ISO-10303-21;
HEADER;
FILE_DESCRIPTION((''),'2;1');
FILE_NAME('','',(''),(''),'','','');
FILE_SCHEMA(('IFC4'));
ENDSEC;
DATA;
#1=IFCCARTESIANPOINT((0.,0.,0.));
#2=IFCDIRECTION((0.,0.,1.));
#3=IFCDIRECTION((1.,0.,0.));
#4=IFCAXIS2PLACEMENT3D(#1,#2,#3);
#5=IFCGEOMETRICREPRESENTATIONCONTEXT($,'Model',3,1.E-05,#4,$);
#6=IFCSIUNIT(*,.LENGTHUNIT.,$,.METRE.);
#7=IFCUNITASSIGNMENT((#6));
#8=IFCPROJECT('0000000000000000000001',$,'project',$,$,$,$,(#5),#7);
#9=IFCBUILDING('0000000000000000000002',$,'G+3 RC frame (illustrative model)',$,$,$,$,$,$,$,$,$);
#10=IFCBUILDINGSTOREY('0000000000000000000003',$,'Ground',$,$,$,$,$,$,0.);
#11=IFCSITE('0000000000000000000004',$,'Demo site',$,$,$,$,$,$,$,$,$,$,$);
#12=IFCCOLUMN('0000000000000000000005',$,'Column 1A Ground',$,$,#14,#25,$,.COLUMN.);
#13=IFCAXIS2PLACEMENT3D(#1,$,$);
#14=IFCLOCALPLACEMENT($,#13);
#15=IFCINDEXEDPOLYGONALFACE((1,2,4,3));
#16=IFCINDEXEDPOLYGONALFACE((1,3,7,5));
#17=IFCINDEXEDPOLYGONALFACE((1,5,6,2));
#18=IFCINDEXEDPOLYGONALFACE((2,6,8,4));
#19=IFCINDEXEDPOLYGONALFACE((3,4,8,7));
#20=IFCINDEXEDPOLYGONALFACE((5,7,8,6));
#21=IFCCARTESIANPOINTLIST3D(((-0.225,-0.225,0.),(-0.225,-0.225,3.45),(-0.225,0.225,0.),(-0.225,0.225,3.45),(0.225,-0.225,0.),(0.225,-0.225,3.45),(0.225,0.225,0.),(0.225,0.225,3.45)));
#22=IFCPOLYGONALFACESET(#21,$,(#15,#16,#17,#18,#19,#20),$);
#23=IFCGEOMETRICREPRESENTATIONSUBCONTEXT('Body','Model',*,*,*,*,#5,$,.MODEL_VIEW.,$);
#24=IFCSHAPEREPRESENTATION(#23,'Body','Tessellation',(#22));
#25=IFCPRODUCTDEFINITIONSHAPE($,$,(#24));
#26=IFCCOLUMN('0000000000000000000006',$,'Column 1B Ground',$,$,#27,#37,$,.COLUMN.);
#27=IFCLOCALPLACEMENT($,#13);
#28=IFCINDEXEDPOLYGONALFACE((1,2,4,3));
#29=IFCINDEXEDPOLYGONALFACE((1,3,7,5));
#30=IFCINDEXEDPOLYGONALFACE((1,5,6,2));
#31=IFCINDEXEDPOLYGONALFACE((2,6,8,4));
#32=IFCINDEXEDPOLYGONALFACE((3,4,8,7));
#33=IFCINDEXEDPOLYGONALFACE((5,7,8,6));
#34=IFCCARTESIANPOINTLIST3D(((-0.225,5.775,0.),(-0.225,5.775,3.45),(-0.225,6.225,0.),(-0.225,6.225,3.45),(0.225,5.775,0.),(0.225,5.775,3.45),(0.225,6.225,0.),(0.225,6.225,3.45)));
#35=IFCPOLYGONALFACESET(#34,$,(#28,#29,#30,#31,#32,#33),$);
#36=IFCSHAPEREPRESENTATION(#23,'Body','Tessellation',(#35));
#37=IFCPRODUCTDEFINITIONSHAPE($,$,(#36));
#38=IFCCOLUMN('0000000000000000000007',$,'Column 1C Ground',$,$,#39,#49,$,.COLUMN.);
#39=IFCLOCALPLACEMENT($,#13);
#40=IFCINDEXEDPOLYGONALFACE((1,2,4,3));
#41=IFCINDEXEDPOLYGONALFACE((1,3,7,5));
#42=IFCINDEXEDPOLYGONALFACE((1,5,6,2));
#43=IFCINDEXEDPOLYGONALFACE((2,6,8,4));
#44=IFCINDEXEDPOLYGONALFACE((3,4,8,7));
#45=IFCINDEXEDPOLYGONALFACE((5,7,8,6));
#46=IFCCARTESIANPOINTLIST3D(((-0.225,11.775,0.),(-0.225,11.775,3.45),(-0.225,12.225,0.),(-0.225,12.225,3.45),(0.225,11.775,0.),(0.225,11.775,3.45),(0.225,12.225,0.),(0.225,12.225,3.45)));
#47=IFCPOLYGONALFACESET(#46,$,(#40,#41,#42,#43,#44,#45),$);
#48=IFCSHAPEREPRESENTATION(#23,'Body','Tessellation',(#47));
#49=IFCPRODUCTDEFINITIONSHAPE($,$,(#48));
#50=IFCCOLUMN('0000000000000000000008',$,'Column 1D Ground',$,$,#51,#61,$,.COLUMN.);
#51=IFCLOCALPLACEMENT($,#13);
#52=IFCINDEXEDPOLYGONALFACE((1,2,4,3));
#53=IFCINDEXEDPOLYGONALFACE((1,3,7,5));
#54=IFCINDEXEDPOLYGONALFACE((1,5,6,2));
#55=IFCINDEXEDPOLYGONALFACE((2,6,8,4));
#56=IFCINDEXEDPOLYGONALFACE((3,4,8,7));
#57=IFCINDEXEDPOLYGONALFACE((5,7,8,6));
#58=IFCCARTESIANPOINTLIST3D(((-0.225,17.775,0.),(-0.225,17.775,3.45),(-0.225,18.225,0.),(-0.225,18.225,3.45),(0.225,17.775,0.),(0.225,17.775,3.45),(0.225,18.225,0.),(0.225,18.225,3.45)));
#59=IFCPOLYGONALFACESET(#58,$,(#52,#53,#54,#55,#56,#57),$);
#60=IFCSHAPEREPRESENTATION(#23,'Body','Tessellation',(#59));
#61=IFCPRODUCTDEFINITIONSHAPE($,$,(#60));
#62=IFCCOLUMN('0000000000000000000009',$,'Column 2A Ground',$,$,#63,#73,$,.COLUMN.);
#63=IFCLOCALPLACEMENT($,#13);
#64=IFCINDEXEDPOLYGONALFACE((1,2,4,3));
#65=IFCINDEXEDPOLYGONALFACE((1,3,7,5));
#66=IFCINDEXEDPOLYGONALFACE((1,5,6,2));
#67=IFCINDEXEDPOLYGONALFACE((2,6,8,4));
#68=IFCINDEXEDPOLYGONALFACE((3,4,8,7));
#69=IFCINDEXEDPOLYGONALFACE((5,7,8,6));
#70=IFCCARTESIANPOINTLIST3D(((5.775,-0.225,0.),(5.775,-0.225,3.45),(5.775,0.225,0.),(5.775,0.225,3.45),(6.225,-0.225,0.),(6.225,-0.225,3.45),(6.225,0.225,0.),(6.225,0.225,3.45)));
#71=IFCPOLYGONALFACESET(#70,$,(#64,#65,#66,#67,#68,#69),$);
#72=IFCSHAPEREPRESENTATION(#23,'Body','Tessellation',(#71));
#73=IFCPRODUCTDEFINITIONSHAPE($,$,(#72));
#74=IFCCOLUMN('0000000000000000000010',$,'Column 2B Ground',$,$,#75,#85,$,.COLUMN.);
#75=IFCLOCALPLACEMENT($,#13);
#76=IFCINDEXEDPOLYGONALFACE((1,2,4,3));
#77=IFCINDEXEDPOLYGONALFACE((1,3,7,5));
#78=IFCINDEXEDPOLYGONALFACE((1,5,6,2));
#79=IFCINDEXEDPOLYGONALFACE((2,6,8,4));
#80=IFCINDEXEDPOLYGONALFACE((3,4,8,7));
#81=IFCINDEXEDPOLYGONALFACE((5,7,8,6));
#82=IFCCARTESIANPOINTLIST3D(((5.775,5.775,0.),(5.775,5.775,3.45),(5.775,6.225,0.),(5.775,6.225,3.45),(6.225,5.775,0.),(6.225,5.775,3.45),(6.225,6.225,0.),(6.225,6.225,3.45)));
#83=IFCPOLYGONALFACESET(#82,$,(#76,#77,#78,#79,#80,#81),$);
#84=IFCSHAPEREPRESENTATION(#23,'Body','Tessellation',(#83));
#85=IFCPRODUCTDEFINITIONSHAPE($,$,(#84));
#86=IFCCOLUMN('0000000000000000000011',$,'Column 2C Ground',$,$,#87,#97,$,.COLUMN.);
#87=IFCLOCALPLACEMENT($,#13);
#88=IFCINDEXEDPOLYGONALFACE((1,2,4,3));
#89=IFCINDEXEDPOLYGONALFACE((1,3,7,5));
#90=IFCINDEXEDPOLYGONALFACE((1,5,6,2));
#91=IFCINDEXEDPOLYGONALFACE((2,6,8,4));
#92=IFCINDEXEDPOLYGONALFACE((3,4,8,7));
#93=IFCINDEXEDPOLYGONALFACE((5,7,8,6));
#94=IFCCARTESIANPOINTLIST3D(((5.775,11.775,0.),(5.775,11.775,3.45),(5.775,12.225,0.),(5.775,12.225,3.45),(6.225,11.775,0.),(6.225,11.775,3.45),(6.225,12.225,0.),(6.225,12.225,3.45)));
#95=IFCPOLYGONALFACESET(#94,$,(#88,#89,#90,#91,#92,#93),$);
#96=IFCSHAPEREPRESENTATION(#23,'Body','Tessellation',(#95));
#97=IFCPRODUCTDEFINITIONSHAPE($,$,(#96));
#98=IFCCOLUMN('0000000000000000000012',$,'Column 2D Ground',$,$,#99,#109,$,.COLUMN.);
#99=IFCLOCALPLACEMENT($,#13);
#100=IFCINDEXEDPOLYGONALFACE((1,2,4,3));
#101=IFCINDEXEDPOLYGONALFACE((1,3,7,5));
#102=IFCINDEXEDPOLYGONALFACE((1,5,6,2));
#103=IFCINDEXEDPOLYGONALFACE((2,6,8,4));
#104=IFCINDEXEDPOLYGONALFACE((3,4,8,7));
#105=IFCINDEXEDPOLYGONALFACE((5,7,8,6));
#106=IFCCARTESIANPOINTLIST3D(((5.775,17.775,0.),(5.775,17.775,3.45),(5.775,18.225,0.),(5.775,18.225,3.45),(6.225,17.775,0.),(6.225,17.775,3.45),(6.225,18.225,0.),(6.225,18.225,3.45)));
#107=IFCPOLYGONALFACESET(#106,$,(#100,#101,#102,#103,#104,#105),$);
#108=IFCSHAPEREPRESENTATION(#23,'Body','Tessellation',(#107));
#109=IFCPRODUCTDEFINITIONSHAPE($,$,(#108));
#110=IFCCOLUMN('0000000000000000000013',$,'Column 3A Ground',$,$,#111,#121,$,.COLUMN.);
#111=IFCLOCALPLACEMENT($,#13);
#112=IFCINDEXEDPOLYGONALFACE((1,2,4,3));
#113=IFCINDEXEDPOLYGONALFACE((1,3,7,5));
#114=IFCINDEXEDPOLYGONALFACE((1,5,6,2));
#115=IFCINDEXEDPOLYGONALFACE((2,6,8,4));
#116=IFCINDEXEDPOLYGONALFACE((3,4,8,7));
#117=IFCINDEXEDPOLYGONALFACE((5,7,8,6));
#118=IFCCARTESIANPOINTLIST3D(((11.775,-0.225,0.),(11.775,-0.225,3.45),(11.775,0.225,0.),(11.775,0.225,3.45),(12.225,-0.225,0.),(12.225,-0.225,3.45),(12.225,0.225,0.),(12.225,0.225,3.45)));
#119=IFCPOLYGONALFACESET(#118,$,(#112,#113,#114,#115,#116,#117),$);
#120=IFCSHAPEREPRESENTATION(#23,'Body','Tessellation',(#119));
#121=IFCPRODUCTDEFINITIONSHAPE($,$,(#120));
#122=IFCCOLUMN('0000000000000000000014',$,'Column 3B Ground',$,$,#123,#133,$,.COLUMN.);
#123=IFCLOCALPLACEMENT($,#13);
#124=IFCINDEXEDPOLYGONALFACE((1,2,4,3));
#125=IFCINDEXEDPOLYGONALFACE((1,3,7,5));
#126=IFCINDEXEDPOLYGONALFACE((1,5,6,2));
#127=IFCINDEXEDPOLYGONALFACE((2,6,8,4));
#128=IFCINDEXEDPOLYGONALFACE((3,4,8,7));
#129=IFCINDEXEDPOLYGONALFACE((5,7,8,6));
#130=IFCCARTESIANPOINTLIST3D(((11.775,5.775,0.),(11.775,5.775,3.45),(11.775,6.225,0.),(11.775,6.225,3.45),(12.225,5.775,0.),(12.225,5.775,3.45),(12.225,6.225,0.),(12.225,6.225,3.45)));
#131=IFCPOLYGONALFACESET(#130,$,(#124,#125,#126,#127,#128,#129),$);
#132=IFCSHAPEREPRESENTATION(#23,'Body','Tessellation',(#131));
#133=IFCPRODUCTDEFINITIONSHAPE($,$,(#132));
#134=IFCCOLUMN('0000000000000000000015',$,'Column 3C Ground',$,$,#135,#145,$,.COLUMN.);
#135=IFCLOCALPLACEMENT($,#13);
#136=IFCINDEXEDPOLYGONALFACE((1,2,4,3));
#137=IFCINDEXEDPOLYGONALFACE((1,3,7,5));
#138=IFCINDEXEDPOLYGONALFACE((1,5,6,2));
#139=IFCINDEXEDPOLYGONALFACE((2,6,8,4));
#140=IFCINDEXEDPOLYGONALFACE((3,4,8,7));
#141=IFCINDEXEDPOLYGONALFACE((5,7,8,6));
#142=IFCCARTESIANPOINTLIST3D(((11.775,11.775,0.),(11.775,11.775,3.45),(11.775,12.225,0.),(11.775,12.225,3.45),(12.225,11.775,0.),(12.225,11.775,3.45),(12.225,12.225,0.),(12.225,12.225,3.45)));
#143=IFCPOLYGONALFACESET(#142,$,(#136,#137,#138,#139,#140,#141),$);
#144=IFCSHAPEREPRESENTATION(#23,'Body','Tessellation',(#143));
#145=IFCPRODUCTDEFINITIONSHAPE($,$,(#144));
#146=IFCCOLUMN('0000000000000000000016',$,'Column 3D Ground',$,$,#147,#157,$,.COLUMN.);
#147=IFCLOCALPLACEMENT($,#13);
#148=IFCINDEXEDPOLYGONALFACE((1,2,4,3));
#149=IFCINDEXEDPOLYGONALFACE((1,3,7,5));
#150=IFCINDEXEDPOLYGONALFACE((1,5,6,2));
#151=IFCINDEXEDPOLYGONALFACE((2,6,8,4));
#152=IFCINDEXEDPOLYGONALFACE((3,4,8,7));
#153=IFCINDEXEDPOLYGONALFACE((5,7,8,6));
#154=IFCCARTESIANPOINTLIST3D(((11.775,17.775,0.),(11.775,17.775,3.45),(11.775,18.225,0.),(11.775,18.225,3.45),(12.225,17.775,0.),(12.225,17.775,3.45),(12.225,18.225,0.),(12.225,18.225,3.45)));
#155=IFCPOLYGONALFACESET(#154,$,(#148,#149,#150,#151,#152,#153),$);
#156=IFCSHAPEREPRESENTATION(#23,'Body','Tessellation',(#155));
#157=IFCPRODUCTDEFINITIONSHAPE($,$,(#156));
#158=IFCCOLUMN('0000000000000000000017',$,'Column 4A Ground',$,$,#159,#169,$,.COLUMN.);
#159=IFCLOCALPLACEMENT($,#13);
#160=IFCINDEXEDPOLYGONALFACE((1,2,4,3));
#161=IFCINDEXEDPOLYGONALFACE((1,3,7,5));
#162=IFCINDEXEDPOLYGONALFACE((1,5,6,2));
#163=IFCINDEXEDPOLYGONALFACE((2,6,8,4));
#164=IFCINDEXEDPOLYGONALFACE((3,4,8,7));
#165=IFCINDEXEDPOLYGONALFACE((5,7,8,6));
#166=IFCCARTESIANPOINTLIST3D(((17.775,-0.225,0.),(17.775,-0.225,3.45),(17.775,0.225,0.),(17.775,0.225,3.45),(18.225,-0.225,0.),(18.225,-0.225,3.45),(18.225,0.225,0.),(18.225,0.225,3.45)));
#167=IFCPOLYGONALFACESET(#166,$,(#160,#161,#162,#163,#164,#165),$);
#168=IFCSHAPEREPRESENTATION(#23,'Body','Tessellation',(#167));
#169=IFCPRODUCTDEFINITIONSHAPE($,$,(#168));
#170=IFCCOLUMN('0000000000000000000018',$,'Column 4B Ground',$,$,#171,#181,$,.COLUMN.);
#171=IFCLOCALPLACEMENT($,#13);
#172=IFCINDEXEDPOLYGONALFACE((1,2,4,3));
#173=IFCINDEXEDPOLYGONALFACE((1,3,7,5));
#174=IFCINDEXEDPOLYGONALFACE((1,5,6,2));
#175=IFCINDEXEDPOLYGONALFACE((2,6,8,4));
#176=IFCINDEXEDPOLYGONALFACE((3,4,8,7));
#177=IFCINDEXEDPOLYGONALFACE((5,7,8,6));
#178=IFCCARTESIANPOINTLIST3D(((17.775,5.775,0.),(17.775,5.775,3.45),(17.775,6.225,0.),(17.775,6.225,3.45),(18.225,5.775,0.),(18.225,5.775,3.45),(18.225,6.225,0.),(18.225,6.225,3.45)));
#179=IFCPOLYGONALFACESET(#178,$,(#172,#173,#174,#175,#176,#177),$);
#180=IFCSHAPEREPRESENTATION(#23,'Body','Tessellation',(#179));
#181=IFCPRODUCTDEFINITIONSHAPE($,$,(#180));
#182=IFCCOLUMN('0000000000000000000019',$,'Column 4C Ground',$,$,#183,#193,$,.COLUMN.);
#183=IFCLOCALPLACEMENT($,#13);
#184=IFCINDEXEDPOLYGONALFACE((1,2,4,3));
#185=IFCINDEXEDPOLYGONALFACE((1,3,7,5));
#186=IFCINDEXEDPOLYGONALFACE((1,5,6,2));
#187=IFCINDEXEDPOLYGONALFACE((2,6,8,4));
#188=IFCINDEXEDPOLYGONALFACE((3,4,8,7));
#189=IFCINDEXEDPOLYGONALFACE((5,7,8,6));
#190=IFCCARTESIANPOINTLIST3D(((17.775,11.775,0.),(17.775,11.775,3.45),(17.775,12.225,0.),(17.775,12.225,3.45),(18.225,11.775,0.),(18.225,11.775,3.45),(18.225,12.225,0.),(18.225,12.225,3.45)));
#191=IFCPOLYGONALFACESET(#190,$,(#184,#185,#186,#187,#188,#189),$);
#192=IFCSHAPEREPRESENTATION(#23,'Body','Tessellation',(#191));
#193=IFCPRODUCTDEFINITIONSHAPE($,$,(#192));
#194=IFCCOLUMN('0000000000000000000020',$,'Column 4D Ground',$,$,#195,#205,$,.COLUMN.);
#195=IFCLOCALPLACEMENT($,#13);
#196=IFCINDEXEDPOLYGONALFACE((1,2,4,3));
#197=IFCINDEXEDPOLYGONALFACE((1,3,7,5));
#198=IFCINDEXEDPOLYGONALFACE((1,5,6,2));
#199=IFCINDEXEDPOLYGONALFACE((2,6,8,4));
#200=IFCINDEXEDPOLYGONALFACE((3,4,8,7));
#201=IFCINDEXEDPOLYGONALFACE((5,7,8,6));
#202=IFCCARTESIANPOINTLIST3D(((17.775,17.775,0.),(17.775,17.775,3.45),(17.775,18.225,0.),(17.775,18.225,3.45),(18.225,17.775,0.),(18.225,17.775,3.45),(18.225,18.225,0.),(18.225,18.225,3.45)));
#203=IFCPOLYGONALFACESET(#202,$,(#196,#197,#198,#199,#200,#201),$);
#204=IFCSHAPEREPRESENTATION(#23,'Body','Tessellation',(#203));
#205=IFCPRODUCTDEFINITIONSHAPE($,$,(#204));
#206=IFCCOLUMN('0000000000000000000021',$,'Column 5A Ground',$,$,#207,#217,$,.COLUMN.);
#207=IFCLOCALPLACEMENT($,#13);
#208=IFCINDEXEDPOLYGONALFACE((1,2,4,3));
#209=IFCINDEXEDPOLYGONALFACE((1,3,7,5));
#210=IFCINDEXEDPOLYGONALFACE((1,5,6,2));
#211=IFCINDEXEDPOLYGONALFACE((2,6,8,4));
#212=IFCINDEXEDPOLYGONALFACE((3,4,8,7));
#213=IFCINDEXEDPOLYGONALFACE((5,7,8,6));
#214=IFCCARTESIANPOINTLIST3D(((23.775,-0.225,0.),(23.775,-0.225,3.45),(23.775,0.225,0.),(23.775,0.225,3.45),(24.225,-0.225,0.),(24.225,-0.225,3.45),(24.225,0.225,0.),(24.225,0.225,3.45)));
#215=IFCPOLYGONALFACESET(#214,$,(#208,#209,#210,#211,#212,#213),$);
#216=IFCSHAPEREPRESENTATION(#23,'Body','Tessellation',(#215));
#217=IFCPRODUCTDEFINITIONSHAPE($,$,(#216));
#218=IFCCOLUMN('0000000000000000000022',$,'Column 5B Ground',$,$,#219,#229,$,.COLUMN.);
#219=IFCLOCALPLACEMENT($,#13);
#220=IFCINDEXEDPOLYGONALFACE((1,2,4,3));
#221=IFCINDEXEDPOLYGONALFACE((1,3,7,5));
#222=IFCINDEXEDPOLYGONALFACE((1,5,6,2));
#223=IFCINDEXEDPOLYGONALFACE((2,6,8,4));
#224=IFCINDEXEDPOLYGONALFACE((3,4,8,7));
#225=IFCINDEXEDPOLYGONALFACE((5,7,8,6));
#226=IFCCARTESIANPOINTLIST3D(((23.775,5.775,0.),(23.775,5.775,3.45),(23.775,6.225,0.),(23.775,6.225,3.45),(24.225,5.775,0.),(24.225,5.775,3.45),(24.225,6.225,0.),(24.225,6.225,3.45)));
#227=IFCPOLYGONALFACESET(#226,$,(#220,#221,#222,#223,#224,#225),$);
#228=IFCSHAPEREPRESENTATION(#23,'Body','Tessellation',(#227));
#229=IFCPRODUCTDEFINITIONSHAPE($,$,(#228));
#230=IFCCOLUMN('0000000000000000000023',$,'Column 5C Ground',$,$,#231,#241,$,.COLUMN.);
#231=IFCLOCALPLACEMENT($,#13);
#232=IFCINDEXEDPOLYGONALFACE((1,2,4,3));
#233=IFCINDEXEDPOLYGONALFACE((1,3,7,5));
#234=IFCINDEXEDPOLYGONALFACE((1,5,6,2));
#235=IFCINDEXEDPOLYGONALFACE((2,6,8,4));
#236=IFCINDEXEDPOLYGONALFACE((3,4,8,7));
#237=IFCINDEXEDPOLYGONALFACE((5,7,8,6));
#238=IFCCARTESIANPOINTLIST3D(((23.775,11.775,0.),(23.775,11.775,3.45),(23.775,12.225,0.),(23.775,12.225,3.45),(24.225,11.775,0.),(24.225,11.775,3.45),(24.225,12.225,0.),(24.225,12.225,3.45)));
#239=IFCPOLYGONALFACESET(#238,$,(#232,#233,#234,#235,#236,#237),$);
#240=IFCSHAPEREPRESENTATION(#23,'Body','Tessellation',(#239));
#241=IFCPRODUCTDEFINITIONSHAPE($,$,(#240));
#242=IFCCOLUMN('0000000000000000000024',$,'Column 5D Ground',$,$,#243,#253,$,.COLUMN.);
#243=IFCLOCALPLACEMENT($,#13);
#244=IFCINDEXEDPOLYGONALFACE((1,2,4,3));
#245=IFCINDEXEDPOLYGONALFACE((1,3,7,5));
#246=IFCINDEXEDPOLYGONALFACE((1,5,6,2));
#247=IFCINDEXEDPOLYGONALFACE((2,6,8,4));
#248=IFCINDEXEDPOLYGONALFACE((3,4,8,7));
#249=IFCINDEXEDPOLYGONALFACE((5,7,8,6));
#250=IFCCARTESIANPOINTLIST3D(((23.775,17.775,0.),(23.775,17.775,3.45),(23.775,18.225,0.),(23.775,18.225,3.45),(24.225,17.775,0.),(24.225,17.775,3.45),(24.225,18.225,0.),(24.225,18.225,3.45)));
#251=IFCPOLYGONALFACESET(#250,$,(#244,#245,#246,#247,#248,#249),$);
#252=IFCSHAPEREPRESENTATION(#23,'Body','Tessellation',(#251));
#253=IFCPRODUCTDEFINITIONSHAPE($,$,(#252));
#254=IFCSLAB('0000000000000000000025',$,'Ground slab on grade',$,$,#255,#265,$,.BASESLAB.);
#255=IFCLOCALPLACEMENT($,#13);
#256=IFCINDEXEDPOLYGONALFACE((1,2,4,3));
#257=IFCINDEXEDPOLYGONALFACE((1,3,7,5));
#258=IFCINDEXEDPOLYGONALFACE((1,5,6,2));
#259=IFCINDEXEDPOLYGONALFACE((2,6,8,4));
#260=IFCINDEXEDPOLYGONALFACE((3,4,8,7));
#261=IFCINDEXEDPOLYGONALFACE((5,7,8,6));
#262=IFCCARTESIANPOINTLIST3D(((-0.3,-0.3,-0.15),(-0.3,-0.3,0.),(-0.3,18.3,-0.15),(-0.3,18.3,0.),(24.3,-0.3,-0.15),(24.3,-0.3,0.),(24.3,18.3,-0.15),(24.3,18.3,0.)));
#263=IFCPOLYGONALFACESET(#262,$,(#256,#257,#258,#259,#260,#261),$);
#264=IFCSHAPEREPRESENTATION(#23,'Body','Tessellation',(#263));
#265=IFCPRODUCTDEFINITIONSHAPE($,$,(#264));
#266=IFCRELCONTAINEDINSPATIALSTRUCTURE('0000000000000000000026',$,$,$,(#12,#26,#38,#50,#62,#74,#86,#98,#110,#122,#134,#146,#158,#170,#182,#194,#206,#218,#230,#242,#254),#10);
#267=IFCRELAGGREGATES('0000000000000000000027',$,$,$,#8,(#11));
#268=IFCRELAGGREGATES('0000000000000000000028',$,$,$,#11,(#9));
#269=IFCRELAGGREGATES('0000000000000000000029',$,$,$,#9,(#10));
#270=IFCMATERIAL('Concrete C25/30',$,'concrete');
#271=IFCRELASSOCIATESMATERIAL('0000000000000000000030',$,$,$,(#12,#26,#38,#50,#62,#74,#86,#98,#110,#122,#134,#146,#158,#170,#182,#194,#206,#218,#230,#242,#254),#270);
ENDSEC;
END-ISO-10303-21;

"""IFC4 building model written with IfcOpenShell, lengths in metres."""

from ifc_helpers import new_model, si_unit, frame, frame_2d, origin, origin_with_axes, place, context, subcontext, project, spatial, rectangle, extrude, material, element, save


model = new_model("IFC4")

# Units and contexts
model_context = context("Model", 3, precision=1e-05, world=origin_with_axes())
body_context = subcontext(model_context, "Body", "Model", "MODEL_VIEW")
ifc_project = project(units=[si_unit("LENGTHUNIT", "METRE")], contexts=[model_context])

# Site, building, storey
site = spatial("IfcSite", under=ifc_project, Name="Demo site")
building = spatial("IfcBuilding", under=site, Name="G+3 RC frame (illustrative model)")
storey = spatial("IfcBuildingStorey", under=building, Name="Ground", Elevation=0.0)

# Columns
ifc_material_1 = material(Name="Concrete C25/30", Category="concrete")
for number, where, z_axis, x_axis, name in (
    (1, (-0.225, -0.225, 0.0), (0.0, 0.0, 1.0), (1.0, 0.0, 0.0), "Column 1A Ground"),
    (2, (-0.225, 5.775, 0.0), (0.0, 0.0, 1.0), (1.0, 0.0, 0.0), "Column 1B Ground"),
    (3, (-0.225, 11.775, 0.0), (0.0, 0.0, 1.0), (1.0, 0.0, 0.0), "Column 1C Ground"),
    (4, (-0.225, 17.775, 0.0), (0.0, 0.0, 1.0), (1.0, 0.0, 0.0), "Column 1D Ground"),
    (5, (5.775, -0.225, 0.0), (0.0, 0.0, 1.0), (1.0, 0.0, 0.0), "Column 2A Ground"),
    (6, (5.775, 5.775, 0.0), (0.0, 0.0, 1.0), (1.0, 0.0, 0.0), "Column 2B Ground"),
    (7, (5.775, 11.775, 0.0), (0.0, 0.0, 1.0), (1.0, 0.0, 0.0), "Column 2C Ground"),
    (8, (5.775, 17.775, 0.0), (0.0, 0.0, 1.0), (1.0, 0.0, 0.0), "Column 2D Ground"),
    (9, (11.775, -0.225, 0.0), (0.0, 0.0, 1.0), (1.0, 0.0, 0.0), "Column 3A Ground"),
    (10, (11.775, 5.775, 0.0), (0.0, 0.0, 1.0), (1.0, 0.0, 0.0), "Column 3B Ground"),
    (11, (11.775, 11.775, 0.0), (0.0, 0.0, 1.0), (1.0, 0.0, 0.0), "Column 3C Ground"),
    (12, (11.775, 17.775, 0.0), (0.0, 0.0, 1.0), (1.0, 0.0, 0.0), "Column 3D Ground"),
    (13, (17.775, -0.225, 0.0), (0.0, 0.0, 1.0), (1.0, 0.0, 0.0), "Column 4A Ground"),
    (14, (17.775, 5.775, 0.0), (0.0, 0.0, 1.0), (1.0, 0.0, 0.0), "Column 4B Ground"),
    (15, (17.775, 11.775, 0.0), (0.0, 0.0, 1.0), (1.0, 0.0, 0.0), "Column 4C Ground"),
    (16, (17.775, 17.775, 0.0), (0.0, 0.0, 1.0), (1.0, 0.0, 0.0), "Column 4D Ground"),
    (17, (23.775, -0.225, 0.0), (0.0, 0.0, 1.0), (1.0, 0.0, 0.0), "Column 5A Ground"),
    (18, (23.775, 5.775, 0.0), (0.0, 0.0, 1.0), (1.0, 0.0, 0.0), "Column 5B Ground"),
    (19, (23.775, 11.775, 0.0), (0.0, 0.0, 1.0), (1.0, 0.0, 0.0), "Column 5C Ground"),
    (20, (23.775, 17.775, 0.0), (0.0, 0.0, 1.0), (1.0, 0.0, 0.0), "Column 5D Ground"),
):
    element("IfcColumn", number, at=place(None, frame(where, z_axis=z_axis, x_axis=x_axis)), inside=storey, material=ifc_material_1, Name=name, PredefinedType="COLUMN", context=body_context, shape_type="SweptSolid", body=[
        extrude(rectangle(XDim=0.45, YDim=0.45, at=frame_2d((0.225, 0.225))), origin(), (0.0, 0.0, 1.0), 3.45),
    ])

# Slab
slab_placement = place(None, frame((-0.3, -0.3, -0.15), z_axis=(0.0, 0.0, 1.0), x_axis=(1.0, 0.0, 0.0)))
element("IfcSlab", 21, at=slab_placement, inside=storey, material=ifc_material_1, Name="Ground slab on grade", PredefinedType="BASESLAB", context=body_context, shape_type="SweptSolid", body=[
    extrude(rectangle(XDim=24.6, YDim=18.6, at=frame_2d((12.3, 9.3))), origin(), (0.0, 0.0, 1.0), 0.15),
])

save(model, "model.ifc")
